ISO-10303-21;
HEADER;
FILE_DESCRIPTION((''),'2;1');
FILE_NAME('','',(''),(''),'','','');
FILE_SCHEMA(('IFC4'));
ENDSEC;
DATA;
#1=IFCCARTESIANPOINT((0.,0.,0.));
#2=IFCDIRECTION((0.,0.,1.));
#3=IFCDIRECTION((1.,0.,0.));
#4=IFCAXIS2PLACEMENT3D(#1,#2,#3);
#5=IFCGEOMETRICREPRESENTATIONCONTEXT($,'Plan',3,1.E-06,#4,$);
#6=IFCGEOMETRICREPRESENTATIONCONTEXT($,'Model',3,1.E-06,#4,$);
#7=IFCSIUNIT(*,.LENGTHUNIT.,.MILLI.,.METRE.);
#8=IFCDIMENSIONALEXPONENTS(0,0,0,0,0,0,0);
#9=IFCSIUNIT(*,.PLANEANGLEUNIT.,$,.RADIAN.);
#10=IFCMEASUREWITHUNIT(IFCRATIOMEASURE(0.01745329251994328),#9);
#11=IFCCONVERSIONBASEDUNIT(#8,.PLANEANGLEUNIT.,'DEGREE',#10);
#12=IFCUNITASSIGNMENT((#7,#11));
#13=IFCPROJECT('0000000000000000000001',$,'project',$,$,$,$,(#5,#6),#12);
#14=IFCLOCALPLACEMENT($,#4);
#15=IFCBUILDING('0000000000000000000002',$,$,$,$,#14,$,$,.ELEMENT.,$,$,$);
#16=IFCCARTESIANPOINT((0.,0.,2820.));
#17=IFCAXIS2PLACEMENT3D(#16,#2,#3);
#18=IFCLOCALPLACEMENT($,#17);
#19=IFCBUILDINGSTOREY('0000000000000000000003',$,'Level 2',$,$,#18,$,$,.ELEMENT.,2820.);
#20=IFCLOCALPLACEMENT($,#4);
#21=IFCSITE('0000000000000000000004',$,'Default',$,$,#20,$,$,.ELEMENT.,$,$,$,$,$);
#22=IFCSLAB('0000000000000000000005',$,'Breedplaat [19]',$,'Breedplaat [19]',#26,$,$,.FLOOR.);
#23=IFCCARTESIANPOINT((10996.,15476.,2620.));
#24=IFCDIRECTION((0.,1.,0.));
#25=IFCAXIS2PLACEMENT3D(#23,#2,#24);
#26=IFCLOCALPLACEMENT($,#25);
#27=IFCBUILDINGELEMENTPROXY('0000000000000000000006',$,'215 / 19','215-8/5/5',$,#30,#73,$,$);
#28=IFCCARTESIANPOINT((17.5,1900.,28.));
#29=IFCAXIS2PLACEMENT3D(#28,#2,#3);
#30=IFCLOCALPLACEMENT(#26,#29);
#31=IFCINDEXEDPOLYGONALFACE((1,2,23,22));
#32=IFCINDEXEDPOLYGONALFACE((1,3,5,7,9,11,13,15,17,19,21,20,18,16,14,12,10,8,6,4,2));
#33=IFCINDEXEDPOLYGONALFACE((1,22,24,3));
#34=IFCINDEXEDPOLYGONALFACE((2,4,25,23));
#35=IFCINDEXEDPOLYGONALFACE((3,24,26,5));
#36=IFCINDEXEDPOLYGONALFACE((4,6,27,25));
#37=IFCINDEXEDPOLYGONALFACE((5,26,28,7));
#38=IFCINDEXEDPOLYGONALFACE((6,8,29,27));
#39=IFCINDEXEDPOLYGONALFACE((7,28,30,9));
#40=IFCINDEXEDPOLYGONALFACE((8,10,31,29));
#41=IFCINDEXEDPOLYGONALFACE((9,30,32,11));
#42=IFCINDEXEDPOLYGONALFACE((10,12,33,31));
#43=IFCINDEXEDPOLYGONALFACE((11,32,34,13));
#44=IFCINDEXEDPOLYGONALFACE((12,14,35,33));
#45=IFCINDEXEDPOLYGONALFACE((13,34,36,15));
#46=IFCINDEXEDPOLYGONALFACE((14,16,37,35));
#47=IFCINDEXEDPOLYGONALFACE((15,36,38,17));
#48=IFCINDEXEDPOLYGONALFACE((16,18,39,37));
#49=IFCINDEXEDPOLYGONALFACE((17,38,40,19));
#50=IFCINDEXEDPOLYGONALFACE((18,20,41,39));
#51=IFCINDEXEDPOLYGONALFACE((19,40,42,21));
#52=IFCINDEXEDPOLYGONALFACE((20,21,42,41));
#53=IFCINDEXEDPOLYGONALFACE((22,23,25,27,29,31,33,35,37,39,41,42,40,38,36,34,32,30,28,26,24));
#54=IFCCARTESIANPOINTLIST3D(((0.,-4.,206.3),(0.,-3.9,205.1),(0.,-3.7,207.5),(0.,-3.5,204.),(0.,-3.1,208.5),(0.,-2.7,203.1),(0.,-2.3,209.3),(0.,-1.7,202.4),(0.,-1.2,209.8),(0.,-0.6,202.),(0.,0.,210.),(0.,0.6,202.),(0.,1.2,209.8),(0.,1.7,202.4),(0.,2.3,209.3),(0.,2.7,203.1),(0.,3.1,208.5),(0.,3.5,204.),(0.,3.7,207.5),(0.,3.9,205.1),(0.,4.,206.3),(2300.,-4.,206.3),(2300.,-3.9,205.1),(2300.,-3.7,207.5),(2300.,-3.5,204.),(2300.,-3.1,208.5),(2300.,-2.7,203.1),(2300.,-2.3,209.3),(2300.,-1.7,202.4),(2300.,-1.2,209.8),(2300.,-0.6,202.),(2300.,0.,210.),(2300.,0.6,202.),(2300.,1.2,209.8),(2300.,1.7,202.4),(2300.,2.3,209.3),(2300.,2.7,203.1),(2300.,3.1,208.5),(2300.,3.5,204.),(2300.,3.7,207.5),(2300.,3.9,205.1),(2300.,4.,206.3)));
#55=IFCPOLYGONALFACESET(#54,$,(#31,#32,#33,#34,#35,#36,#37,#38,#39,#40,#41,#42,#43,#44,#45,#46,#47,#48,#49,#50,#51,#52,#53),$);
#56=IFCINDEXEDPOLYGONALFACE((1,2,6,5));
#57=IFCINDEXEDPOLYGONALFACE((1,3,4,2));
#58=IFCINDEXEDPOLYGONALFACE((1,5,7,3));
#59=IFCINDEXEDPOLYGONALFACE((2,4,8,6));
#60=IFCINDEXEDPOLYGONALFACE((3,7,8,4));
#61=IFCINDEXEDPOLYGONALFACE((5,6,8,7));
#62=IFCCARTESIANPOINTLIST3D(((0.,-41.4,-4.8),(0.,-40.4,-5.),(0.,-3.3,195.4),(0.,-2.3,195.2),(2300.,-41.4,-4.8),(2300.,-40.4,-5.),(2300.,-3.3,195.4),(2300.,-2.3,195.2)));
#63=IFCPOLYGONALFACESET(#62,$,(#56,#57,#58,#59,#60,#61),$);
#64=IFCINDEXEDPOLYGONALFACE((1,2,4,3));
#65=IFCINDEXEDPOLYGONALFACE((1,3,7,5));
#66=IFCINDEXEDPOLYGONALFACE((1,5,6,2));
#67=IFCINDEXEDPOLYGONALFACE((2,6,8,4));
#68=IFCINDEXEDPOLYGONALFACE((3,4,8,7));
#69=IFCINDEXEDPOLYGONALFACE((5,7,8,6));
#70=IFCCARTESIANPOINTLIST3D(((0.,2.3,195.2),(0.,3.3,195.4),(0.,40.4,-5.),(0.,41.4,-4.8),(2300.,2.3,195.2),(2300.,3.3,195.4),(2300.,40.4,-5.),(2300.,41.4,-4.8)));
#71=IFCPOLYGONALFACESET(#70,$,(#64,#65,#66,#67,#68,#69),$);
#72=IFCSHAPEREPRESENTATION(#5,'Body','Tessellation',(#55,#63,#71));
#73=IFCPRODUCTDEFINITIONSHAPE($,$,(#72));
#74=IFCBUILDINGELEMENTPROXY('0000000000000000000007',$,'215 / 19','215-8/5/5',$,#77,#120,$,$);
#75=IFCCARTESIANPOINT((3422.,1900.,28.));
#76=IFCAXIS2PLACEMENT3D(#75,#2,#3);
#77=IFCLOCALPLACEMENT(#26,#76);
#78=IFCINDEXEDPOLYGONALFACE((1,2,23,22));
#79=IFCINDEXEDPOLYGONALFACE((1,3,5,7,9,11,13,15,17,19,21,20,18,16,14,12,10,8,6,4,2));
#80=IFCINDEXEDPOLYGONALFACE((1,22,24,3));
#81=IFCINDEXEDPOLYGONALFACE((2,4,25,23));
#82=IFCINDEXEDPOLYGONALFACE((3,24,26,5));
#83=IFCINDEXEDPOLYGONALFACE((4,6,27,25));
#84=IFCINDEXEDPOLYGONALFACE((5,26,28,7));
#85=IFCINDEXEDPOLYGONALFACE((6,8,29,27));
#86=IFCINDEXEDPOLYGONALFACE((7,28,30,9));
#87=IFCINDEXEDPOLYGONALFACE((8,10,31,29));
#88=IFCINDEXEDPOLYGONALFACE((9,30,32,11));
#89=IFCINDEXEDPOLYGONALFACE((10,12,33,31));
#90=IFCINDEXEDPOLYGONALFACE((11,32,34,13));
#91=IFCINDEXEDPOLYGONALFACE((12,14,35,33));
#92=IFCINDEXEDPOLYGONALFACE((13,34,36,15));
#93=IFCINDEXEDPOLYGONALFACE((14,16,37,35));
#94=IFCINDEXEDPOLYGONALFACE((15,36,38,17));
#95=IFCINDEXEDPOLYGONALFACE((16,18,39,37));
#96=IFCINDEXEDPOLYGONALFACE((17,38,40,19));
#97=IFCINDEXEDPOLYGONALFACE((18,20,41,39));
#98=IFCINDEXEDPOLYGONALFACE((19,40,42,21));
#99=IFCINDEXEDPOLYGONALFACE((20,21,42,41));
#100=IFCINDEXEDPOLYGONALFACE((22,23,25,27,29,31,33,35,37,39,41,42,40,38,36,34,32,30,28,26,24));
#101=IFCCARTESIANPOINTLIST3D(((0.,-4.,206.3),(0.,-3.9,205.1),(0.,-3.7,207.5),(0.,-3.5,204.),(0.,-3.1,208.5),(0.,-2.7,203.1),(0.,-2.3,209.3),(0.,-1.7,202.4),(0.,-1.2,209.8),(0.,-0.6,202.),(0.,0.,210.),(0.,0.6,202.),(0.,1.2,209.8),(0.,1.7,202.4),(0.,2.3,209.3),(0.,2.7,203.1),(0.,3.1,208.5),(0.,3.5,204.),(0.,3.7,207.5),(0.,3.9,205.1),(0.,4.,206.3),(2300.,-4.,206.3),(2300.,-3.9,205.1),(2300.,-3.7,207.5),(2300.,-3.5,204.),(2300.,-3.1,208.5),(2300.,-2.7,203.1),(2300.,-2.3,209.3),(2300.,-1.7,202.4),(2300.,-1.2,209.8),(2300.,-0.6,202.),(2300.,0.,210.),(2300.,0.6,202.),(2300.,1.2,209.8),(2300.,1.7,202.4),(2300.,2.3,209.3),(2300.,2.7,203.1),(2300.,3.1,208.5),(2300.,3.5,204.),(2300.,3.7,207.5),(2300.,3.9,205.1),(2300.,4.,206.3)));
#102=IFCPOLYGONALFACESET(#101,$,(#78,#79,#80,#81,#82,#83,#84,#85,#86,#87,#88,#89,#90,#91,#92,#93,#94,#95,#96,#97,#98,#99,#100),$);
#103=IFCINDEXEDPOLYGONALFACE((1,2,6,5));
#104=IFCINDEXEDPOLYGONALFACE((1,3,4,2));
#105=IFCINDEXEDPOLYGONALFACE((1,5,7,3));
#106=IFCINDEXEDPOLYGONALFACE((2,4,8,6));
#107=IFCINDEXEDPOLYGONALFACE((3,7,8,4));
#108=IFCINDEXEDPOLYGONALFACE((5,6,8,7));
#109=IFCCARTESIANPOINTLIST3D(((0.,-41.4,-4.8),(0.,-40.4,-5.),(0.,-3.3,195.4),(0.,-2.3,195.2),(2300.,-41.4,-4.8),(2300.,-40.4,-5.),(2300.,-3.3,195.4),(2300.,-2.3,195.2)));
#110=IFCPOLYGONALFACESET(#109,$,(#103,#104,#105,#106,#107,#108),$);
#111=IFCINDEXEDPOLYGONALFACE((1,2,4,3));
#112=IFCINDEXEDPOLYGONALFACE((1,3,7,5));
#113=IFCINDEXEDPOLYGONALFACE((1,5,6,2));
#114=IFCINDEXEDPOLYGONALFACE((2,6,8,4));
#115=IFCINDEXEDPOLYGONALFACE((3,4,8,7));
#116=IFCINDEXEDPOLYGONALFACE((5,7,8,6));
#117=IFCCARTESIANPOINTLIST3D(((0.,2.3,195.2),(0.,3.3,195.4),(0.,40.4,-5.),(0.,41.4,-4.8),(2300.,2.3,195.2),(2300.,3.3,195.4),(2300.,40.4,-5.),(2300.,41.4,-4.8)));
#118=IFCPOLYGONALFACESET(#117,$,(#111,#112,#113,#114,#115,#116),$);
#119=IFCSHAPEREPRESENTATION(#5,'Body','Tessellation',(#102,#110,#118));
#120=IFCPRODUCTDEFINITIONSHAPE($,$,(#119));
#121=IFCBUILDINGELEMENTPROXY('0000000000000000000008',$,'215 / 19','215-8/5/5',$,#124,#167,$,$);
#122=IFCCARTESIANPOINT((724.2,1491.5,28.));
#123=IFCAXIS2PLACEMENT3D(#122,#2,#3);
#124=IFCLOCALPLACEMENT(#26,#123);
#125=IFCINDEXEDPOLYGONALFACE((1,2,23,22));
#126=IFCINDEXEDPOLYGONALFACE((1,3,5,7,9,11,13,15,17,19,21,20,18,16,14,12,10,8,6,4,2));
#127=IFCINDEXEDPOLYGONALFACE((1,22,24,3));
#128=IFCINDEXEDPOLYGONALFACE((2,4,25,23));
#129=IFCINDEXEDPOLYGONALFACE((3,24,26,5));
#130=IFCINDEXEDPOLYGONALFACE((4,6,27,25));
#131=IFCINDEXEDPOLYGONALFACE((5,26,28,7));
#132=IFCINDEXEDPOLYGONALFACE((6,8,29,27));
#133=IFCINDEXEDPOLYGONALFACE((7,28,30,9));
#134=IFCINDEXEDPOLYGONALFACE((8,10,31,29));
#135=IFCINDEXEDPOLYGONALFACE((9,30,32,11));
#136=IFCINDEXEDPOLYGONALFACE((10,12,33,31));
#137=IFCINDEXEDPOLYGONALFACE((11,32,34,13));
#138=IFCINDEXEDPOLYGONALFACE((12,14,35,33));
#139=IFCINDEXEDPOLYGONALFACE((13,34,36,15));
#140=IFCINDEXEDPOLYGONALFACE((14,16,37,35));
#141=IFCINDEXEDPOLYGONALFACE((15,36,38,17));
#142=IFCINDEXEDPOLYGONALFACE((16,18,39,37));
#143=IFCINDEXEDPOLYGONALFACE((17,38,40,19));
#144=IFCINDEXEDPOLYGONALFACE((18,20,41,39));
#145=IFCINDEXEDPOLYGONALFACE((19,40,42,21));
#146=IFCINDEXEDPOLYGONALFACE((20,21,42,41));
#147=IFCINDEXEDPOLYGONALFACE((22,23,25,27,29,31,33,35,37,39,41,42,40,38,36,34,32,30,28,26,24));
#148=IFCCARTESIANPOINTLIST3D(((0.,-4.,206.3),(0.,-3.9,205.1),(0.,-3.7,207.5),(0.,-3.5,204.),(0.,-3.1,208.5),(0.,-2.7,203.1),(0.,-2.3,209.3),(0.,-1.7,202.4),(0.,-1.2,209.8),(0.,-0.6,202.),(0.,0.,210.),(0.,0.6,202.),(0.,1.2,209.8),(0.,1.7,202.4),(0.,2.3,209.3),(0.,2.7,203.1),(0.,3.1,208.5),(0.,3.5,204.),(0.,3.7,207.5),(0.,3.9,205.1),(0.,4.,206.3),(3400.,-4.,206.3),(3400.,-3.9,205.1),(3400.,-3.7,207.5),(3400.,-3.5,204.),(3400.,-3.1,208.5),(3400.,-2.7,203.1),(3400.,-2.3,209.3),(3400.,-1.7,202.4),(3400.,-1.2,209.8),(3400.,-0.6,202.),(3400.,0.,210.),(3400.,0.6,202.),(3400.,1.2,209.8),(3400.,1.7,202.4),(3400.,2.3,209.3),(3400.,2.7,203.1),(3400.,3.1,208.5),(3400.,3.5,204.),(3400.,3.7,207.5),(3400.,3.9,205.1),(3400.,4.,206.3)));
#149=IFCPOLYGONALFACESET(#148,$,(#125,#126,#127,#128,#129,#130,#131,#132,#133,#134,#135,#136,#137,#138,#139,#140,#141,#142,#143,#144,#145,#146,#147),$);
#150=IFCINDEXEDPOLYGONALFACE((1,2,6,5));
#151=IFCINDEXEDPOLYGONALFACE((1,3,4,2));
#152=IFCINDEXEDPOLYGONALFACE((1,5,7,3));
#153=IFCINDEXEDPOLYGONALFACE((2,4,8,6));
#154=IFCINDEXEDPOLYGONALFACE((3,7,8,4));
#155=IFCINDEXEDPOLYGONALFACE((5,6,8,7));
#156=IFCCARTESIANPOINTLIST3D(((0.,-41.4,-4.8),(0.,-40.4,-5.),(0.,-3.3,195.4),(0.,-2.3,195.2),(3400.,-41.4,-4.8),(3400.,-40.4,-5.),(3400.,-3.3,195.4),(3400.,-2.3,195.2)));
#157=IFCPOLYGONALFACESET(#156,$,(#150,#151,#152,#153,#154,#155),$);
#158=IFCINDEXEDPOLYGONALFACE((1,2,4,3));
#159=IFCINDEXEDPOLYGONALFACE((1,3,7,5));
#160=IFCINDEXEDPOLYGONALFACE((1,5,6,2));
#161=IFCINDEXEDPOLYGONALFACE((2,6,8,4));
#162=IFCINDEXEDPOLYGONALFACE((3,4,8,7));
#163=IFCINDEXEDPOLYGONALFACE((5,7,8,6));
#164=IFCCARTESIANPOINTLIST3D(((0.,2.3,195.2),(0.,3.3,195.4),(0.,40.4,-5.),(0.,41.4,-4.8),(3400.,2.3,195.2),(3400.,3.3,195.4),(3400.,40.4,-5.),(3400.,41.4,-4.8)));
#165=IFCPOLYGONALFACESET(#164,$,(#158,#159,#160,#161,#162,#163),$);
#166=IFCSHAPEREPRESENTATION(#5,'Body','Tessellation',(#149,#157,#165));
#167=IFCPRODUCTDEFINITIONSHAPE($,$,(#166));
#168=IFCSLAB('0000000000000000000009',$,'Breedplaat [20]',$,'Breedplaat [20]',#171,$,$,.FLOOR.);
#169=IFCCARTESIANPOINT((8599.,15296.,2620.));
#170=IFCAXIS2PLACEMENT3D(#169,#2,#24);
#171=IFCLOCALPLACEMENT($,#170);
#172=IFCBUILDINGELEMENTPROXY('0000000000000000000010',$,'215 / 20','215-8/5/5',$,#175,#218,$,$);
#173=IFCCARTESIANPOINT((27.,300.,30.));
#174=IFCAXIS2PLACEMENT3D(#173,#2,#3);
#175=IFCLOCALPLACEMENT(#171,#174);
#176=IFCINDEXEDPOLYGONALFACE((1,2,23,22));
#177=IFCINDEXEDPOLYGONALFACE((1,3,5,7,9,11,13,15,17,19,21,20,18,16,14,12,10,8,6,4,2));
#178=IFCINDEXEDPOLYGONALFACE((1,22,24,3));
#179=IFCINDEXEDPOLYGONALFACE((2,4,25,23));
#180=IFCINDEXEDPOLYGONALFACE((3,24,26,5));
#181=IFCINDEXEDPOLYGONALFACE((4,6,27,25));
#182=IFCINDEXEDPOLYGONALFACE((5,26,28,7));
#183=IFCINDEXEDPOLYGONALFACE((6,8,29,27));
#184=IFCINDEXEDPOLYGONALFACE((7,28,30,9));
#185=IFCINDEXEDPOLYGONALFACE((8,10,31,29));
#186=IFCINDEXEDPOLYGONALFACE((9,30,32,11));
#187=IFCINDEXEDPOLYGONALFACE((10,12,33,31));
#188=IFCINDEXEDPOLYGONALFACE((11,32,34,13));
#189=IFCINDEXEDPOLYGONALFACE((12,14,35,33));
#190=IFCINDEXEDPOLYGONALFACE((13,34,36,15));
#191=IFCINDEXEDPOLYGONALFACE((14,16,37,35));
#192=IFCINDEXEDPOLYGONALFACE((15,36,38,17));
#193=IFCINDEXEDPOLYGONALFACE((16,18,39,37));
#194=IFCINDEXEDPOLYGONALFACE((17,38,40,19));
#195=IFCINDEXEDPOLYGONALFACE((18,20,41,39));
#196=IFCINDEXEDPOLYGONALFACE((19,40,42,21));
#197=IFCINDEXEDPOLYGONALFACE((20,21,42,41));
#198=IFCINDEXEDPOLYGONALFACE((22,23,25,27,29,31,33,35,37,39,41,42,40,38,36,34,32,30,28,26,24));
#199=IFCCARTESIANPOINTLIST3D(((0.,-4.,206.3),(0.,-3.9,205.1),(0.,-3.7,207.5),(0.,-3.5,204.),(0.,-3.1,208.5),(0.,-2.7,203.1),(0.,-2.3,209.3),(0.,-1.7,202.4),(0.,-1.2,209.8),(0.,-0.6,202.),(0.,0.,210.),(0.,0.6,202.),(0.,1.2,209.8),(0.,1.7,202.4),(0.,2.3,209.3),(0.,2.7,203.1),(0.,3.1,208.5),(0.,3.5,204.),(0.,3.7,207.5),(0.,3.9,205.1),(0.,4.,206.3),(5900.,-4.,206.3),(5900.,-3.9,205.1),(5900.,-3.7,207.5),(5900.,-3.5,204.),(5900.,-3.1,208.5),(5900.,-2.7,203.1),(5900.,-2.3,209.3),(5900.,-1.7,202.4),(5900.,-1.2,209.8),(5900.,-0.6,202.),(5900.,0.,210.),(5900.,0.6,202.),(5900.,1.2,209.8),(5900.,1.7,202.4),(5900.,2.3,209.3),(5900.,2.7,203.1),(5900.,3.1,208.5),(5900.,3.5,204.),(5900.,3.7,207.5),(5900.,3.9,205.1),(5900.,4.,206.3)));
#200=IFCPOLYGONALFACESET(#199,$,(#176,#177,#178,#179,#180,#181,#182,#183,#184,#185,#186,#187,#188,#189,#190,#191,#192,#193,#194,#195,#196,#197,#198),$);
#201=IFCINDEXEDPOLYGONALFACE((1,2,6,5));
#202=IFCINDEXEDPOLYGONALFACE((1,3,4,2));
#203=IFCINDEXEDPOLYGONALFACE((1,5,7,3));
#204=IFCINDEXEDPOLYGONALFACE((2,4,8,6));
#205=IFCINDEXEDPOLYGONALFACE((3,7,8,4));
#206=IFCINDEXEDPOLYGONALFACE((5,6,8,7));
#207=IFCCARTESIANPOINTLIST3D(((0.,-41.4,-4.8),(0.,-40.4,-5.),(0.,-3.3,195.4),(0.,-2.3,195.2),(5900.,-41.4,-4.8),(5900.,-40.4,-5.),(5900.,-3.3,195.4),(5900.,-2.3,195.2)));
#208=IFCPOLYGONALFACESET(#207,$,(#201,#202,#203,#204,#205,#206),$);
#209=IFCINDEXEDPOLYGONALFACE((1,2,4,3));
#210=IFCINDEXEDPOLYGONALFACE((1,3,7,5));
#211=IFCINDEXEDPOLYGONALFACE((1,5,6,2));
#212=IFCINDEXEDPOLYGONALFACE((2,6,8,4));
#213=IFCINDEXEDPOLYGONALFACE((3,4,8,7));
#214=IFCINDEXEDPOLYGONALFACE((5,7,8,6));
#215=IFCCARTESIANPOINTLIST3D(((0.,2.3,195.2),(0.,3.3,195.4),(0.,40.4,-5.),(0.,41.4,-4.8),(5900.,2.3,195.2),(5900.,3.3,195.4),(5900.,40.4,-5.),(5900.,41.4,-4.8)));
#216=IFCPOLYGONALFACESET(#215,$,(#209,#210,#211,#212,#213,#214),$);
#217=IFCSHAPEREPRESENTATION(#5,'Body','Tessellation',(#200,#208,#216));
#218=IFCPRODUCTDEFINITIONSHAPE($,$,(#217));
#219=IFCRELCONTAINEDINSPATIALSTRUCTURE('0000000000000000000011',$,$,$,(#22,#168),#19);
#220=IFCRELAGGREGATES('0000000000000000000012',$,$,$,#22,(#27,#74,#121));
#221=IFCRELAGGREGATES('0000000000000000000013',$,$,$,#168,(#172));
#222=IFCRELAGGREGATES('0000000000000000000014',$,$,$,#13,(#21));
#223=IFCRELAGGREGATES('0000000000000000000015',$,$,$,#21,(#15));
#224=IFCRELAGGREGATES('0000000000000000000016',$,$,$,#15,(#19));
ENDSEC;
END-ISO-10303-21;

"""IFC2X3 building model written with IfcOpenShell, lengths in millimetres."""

from ifc_helpers import new_model, entity, si_unit, converted_unit, frame, origin_with_axes, origin_2d_with_axis, place, context, project, spatial, rectangle, circle, extrude, element, aggregate, save


model = new_model("IFC2X3")

# Units and contexts
plan_context = context("Plan", 3, precision=1e-06, world=origin_with_axes())
model_context = context("Model", 3, precision=1e-06, world=origin_with_axes())
ifc_project = project(units=[si_unit("LENGTHUNIT", "METRE", prefix="MILLI"), converted_unit("PLANEANGLEUNIT", "DEGREE", entity("IfcRatioMeasure", 0.01745329251994328), si_unit("PLANEANGLEUNIT", "RADIAN"), dimensions=[0, 0, 0, 0, 0, 0, 0])], contexts=[plan_context, model_context])

# Site, building, storey
site_placement = place(None, origin_with_axes())
site = spatial("IfcSite", under=ifc_project, at=site_placement, Name="Default", CompositionType="ELEMENT")
building_placement = place(None, origin_with_axes())
building = spatial("IfcBuilding", under=site, at=building_placement, CompositionType="ELEMENT")
storey_placement = place(None, frame((0.0, 0.0, 2820.0), z_axis=(0.0, 0.0, 1.0), x_axis=(1.0, 0.0, 0.0)))
storey = spatial("IfcBuildingStorey", under=building, at=storey_placement, Name="Level 2", CompositionType="ELEMENT", Elevation=2820.0)

# Slab, building element proxies
slab_1_placement = place(None, frame((10996.0, 15476.0, 2620.0), z_axis=(0.0, 0.0, 1.0), x_axis=(0.0, 1.0, 0.0)))
slab_1 = element("IfcSlab", 1, at=slab_1_placement, inside=storey, Name="Breedplaat [19]", ObjectType="Breedplaat [19]", PredefinedType="FLOOR")
proxy_1_placement = place(slab_1_placement, frame((17.5, 1900.0, 28.0), z_axis=(0.0, 0.0, 1.0), x_axis=(1.0, 0.0, 0.0)))
proxy_1 = element("IfcBuildingElementProxy", 2, at=proxy_1_placement, Name="215 / 19", Description="215-8/5/5", context=plan_context, shape_type="SweptSolid", body=[
    extrude(circle(Radius=4.0, at=origin_2d_with_axis()), frame((0.0, 0.0, 206.0), z_axis=(1.0, 0.0, 0.0), x_axis=(0.0, 0.0, 1.0)), (0.0, 0.0, 1.0), 2300.0),
    extrude(rectangle(XDim=203.8, YDim=1.0, at=origin_2d_with_axis()), frame((0.0, -21.9, 95.2), z_axis=(1.0, 0.0, 0.0), x_axis=(0.0, 0.187112, 0.982339)), (0.0, 0.0, 1.0), 2300.0),
    extrude(rectangle(XDim=203.8, YDim=1.0, at=origin_2d_with_axis()), frame((0.0, 21.9, 95.2), z_axis=(1.0, 0.0, 0.0), x_axis=(0.0, -0.187112, 0.982339)), (0.0, 0.0, 1.0), 2300.0),
])
proxy_2_placement = place(slab_1_placement, frame((3422.0, 1900.0, 28.0), z_axis=(0.0, 0.0, 1.0), x_axis=(1.0, 0.0, 0.0)))
proxy_2 = element("IfcBuildingElementProxy", 3, at=proxy_2_placement, Name="215 / 19", Description="215-8/5/5", context=plan_context, shape_type="SweptSolid", body=[
    extrude(circle(Radius=4.0, at=origin_2d_with_axis()), frame((0.0, 0.0, 206.0), z_axis=(1.0, 0.0, 0.0), x_axis=(0.0, 0.0, 1.0)), (0.0, 0.0, 1.0), 2300.0),
    extrude(rectangle(XDim=203.8, YDim=1.0, at=origin_2d_with_axis()), frame((0.0, -21.9, 95.2), z_axis=(1.0, 0.0, 0.0), x_axis=(0.0, 0.187112, 0.982339)), (0.0, 0.0, 1.0), 2300.0),
    extrude(rectangle(XDim=203.8, YDim=1.0, at=origin_2d_with_axis()), frame((0.0, 21.9, 95.2), z_axis=(1.0, 0.0, 0.0), x_axis=(0.0, -0.187112, 0.982339)), (0.0, 0.0, 1.0), 2300.0),
])
proxy_3_placement = place(slab_1_placement, frame((724.2, 1491.5, 28.0), z_axis=(0.0, 0.0, 1.0), x_axis=(1.0, 0.0, 0.0)))
proxy_3 = element("IfcBuildingElementProxy", 4, at=proxy_3_placement, Name="215 / 19", Description="215-8/5/5", context=plan_context, shape_type="SweptSolid", body=[
    extrude(circle(Radius=4.0, at=origin_2d_with_axis()), frame((0.0, 0.0, 206.0), z_axis=(1.0, 0.0, 0.0), x_axis=(0.0, 0.0, 1.0)), (0.0, 0.0, 1.0), 3400.0),
    extrude(rectangle(XDim=203.8, YDim=1.0, at=origin_2d_with_axis()), frame((0.0, -21.9, 95.2), z_axis=(1.0, 0.0, 0.0), x_axis=(0.0, 0.187112, 0.982339)), (0.0, 0.0, 1.0), 3400.0),
    extrude(rectangle(XDim=203.8, YDim=1.0, at=origin_2d_with_axis()), frame((0.0, 21.9, 95.2), z_axis=(1.0, 0.0, 0.0), x_axis=(0.0, -0.187112, 0.982339)), (0.0, 0.0, 1.0), 3400.0),
])
aggregate(slab_1, [proxy_1, proxy_2, proxy_3])

# Slab, building element proxy
slab_2_placement = place(None, frame((8599.0, 15296.0, 2620.0), z_axis=(0.0, 0.0, 1.0), x_axis=(0.0, 1.0, 0.0)))
slab_2 = element("IfcSlab", 5, at=slab_2_placement, inside=storey, Name="Breedplaat [20]", ObjectType="Breedplaat [20]", PredefinedType="FLOOR")
proxy_4_placement = place(slab_2_placement, frame((27.0, 300.0, 30.0), z_axis=(0.0, 0.0, 1.0), x_axis=(1.0, 0.0, 0.0)))
proxy_4 = element("IfcBuildingElementProxy", 6, at=proxy_4_placement, Name="215 / 20", Description="215-8/5/5", context=plan_context, shape_type="SweptSolid", body=[
    extrude(circle(Radius=4.0, at=origin_2d_with_axis()), frame((0.0, 0.0, 206.0), z_axis=(1.0, 0.0, 0.0), x_axis=(0.0, 0.0, 1.0)), (0.0, 0.0, 1.0), 5900.0),
    extrude(rectangle(XDim=203.8, YDim=1.0, at=origin_2d_with_axis()), frame((0.0, -21.9, 95.2), z_axis=(1.0, 0.0, 0.0), x_axis=(0.0, 0.187112, 0.982339)), (0.0, 0.0, 1.0), 5900.0),
    extrude(rectangle(XDim=203.8, YDim=1.0, at=origin_2d_with_axis()), frame((0.0, 21.9, 95.2), z_axis=(1.0, 0.0, 0.0), x_axis=(0.0, -0.187112, 0.982339)), (0.0, 0.0, 1.0), 5900.0),
])
aggregate(slab_2, [proxy_4])

save(model, "model.ifc")
